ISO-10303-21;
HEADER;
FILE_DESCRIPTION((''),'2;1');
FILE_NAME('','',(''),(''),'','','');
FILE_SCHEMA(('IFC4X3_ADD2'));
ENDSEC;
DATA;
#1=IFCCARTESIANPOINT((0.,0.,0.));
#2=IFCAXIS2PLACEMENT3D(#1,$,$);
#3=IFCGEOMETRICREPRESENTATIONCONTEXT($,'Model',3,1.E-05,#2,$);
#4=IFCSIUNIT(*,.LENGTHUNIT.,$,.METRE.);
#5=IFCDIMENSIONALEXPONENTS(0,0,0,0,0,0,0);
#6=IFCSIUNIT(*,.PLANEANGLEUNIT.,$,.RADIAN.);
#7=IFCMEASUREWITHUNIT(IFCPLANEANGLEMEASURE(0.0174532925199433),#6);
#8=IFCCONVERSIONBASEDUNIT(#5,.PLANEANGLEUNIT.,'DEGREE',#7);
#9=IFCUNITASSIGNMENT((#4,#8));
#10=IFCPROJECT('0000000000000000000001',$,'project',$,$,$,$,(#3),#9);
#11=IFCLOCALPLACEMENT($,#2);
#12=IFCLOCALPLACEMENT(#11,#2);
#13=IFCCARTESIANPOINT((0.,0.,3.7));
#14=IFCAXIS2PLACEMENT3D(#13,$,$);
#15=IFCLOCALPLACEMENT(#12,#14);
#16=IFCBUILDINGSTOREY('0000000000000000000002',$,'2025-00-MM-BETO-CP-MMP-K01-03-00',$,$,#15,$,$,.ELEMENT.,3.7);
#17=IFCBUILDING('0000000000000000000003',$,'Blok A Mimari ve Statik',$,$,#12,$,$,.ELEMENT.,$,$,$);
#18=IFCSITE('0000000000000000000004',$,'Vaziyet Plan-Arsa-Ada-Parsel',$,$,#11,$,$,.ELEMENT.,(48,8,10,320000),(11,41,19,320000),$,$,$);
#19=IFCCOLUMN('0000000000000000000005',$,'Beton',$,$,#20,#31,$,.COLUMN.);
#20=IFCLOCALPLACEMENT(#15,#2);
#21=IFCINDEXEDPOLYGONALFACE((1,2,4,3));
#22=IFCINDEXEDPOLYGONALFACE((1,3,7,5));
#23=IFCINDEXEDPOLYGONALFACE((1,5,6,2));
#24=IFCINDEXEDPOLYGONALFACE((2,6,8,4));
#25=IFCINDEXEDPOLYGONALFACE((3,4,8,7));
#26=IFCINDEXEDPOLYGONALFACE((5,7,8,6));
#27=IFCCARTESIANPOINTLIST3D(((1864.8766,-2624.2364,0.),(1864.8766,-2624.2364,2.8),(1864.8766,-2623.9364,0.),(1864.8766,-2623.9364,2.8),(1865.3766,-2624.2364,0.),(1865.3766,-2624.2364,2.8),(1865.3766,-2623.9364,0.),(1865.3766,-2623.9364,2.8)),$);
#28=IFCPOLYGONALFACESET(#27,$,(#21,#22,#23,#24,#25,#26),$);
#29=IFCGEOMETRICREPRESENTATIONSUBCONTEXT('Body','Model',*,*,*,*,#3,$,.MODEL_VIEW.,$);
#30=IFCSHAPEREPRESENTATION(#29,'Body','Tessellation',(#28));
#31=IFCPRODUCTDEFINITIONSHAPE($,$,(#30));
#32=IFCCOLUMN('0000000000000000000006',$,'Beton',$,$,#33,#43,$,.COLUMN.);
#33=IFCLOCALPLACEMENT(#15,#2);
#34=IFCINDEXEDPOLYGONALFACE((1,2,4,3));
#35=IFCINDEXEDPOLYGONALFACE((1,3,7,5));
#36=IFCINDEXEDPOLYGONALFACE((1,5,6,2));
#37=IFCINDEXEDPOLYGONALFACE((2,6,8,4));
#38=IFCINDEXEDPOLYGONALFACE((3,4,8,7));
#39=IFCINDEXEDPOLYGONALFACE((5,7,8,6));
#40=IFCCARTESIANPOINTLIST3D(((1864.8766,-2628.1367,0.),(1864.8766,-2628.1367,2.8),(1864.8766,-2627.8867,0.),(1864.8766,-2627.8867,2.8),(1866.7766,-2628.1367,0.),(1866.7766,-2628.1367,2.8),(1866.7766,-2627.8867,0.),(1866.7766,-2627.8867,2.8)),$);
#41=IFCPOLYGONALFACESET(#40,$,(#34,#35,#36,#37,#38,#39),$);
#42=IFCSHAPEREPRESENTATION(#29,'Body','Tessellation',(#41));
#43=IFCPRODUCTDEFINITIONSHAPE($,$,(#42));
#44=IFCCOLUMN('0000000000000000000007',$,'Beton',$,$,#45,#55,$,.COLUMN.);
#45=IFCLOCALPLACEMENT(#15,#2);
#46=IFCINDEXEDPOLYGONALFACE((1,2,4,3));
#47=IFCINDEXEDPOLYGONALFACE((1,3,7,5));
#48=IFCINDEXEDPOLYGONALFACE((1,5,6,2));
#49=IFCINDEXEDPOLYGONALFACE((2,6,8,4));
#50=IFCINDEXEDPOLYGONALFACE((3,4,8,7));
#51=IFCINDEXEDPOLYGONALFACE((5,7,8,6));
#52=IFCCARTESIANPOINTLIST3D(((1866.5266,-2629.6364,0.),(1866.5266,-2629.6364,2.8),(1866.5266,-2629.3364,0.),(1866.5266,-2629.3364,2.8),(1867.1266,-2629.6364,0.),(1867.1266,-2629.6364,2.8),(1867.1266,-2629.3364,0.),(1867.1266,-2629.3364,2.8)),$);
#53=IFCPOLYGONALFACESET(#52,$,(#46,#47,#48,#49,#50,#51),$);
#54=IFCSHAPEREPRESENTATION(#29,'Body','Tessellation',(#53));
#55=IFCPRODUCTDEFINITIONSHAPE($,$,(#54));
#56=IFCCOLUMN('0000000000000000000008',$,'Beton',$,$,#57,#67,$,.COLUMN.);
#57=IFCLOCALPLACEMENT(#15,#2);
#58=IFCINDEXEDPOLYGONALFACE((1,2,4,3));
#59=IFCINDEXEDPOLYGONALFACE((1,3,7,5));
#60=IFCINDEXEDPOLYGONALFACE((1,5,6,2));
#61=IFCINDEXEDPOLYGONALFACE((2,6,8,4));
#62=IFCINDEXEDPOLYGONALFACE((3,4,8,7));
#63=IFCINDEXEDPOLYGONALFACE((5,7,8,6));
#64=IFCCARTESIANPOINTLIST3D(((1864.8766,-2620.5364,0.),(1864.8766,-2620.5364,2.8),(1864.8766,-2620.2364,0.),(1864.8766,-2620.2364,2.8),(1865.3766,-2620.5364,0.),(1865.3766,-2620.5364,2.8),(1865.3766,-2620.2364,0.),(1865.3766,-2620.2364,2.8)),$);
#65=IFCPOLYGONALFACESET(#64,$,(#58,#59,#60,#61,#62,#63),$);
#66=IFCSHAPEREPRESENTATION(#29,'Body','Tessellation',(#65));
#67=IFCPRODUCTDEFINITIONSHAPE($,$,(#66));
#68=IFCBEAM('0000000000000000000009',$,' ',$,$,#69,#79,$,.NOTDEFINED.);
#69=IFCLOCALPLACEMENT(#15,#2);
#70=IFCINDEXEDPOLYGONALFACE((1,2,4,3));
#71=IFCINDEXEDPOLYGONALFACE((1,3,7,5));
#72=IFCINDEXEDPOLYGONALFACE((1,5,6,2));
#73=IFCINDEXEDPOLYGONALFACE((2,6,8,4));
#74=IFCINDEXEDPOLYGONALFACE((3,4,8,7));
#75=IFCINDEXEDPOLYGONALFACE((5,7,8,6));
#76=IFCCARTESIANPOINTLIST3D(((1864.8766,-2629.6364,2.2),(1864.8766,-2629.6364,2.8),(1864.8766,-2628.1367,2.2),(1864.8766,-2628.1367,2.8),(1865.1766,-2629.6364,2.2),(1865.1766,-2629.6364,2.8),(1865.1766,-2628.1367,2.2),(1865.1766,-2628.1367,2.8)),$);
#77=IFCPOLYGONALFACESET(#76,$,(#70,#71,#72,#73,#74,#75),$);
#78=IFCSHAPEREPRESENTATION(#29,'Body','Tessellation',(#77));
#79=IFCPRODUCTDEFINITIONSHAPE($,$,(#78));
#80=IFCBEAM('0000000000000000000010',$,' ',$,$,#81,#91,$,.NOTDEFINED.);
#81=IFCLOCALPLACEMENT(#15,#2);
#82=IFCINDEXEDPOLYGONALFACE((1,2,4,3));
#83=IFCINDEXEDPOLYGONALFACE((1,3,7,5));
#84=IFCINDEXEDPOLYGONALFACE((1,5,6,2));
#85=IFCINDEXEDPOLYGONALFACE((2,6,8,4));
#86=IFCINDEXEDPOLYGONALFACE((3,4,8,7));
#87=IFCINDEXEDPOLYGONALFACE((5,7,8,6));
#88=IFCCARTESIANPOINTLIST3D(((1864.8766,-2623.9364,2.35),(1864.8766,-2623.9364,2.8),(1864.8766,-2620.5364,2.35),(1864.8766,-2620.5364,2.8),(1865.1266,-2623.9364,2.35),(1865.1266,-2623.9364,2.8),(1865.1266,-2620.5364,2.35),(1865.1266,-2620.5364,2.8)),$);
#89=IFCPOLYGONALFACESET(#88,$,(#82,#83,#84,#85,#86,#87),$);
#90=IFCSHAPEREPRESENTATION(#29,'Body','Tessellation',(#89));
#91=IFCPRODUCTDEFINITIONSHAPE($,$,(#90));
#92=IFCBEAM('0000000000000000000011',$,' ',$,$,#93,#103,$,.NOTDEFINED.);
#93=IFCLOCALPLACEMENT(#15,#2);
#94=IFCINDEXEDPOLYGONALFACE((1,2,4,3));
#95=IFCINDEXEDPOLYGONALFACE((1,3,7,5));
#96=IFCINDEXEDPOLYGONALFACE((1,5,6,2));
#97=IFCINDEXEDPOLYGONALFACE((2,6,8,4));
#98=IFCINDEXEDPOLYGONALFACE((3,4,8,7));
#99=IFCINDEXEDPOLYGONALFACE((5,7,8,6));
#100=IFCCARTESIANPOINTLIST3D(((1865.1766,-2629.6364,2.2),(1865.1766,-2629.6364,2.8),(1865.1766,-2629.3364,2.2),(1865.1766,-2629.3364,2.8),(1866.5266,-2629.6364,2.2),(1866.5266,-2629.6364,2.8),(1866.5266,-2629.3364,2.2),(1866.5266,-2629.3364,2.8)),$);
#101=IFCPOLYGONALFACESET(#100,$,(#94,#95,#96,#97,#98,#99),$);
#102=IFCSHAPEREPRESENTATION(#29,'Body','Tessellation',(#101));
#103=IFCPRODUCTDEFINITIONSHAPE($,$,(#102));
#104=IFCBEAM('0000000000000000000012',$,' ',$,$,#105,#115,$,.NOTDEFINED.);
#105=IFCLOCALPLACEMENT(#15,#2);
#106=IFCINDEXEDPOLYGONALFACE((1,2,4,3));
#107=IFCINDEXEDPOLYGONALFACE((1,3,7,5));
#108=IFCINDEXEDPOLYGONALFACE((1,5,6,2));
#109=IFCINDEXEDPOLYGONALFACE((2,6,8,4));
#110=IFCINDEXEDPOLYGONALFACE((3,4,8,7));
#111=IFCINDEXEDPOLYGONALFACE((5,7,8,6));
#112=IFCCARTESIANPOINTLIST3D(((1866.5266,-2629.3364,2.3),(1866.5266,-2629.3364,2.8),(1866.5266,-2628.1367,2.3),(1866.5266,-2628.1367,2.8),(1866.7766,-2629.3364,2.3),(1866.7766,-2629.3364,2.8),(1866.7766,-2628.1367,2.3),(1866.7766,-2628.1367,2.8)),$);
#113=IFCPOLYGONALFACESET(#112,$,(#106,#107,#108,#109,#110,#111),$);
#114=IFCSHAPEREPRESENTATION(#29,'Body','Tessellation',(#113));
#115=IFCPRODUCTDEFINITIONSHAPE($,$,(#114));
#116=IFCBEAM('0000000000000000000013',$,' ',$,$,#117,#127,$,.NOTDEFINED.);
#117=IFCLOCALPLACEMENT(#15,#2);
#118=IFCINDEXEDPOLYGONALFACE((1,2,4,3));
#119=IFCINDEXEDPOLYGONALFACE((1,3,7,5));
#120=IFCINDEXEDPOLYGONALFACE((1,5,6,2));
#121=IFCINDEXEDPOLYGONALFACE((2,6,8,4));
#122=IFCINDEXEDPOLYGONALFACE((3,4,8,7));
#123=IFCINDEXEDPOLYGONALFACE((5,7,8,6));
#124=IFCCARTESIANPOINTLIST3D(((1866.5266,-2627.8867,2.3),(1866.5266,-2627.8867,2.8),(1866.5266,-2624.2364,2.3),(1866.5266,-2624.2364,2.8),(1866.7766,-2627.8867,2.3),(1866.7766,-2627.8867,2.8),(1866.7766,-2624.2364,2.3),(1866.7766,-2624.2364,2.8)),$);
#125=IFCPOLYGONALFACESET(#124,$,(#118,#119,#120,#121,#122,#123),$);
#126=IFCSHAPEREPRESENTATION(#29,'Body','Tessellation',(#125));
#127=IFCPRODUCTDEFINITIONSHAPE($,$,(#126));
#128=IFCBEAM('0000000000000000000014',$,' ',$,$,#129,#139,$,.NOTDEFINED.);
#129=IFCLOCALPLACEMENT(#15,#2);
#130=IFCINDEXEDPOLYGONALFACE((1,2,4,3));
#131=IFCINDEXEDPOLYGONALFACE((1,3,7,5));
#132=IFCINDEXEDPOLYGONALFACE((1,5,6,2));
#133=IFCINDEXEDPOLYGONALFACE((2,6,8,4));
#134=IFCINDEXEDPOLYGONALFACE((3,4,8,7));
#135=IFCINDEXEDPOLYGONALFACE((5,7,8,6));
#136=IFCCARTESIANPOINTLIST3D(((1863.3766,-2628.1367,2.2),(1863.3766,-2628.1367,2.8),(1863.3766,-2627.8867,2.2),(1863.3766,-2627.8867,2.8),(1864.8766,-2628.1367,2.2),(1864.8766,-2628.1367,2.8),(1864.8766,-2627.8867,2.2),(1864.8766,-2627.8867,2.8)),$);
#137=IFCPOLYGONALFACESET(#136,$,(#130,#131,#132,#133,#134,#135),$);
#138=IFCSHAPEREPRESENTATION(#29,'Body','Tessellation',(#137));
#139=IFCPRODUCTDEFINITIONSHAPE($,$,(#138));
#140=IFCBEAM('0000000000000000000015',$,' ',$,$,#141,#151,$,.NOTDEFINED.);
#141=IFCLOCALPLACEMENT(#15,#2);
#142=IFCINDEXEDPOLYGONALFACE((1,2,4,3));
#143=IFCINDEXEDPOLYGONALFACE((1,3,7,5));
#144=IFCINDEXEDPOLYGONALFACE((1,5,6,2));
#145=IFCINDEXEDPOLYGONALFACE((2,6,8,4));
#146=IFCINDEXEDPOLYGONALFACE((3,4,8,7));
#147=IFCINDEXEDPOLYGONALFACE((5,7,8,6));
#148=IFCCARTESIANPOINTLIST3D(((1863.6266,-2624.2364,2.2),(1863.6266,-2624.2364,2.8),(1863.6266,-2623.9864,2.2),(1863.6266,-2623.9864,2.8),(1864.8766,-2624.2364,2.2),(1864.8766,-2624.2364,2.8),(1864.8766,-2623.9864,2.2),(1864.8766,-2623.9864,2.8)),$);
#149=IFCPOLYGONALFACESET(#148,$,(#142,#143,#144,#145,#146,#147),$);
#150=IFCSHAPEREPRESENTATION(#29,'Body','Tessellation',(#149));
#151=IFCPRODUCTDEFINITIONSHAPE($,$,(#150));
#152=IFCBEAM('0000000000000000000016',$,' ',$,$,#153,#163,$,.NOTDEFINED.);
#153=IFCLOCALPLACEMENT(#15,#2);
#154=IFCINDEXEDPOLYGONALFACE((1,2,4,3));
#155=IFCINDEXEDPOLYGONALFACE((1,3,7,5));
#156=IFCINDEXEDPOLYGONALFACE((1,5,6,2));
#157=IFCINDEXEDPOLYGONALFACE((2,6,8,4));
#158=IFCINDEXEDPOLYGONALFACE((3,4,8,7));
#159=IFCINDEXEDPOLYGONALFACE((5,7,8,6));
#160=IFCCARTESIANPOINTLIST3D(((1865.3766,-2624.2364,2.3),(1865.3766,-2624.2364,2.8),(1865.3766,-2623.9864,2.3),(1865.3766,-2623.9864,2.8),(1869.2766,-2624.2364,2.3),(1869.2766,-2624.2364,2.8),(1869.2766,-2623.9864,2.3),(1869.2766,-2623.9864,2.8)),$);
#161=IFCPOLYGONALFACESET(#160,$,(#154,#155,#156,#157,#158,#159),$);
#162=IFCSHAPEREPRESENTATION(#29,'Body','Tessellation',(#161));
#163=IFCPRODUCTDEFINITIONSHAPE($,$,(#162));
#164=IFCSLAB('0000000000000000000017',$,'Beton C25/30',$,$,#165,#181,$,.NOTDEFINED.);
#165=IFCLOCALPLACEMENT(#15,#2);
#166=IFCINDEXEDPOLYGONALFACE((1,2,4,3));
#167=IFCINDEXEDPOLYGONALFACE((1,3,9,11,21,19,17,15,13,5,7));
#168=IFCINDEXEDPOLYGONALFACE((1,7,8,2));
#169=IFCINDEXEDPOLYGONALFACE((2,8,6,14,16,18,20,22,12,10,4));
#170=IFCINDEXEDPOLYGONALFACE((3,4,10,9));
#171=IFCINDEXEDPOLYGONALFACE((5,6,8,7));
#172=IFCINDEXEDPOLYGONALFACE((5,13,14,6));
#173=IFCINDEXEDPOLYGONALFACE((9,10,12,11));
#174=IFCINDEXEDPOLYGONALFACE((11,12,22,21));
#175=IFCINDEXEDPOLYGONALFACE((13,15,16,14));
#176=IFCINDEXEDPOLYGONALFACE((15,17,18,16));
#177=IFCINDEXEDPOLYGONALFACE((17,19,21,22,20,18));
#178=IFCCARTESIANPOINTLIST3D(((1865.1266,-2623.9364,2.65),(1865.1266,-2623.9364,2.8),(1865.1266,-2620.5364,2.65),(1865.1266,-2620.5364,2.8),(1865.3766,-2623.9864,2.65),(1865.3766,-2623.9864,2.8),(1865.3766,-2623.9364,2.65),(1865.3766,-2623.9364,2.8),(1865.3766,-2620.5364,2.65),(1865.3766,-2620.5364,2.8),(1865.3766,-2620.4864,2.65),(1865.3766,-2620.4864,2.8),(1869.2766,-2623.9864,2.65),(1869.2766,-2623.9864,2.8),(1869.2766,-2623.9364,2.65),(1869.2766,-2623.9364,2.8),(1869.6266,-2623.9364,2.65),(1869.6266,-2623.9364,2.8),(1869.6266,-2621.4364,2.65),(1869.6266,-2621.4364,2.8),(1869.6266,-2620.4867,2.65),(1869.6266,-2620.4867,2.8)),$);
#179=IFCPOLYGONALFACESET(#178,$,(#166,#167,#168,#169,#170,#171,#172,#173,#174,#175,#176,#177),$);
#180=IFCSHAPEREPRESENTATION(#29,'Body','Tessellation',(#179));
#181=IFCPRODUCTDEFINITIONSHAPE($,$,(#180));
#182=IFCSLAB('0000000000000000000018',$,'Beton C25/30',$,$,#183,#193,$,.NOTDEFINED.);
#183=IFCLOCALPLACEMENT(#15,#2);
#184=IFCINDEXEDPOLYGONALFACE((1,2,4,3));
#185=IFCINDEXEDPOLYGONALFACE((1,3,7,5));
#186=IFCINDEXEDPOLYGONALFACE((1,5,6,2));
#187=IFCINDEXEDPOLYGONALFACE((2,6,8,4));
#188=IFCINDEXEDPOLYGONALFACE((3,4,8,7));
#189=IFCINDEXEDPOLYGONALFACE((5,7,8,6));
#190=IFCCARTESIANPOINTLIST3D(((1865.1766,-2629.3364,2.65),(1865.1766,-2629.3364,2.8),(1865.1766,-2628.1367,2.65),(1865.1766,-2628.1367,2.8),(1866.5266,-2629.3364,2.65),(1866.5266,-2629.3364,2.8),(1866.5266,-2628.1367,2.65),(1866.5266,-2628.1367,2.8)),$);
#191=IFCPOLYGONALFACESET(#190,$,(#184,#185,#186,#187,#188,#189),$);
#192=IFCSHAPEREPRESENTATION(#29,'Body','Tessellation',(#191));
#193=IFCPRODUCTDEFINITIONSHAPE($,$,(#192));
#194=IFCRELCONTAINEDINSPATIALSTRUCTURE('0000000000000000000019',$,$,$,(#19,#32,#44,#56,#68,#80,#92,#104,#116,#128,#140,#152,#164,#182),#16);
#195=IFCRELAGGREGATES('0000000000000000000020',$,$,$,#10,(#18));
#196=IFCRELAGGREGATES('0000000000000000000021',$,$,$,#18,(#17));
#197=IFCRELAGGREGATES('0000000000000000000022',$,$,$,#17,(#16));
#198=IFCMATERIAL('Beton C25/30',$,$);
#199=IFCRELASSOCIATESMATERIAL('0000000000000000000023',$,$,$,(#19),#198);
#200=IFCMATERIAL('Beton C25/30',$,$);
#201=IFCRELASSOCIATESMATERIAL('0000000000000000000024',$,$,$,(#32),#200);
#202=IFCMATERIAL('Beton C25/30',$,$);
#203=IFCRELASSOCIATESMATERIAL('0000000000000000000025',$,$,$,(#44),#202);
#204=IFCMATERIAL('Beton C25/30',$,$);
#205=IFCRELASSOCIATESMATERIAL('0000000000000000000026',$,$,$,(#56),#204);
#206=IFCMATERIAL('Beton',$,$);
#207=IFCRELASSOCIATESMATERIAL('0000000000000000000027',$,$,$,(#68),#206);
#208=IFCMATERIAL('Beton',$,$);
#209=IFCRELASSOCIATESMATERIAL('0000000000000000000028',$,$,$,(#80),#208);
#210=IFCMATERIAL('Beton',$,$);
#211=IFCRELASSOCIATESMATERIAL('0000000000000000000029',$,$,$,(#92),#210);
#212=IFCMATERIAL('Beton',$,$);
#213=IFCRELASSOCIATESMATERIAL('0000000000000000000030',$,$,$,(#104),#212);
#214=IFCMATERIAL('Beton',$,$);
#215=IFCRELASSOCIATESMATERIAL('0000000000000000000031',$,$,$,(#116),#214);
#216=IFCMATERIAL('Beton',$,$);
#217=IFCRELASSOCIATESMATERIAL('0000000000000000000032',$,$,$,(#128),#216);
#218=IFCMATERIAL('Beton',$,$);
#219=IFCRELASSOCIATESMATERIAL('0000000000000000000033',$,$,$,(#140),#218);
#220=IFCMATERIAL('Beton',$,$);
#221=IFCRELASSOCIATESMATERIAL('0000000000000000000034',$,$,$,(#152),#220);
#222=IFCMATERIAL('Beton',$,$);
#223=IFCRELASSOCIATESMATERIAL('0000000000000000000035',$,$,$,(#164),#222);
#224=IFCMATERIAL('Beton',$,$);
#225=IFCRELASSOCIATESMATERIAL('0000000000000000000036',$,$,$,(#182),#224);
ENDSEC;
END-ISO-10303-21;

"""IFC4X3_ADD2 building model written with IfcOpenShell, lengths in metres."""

from ifc_helpers import new_model, entity, si_unit, converted_unit, frame, frame_2d, origin, origin_with_axes, place, context, subcontext, project, spatial, polyline, rectangle, outline, extrude, material, element, save


model = new_model("IFC4X3_ADD2")

# Units and contexts
model_context = context("Model", 3, precision=1e-05, world=origin())
body_context = subcontext(model_context, "Body", "Model", "MODEL_VIEW")
ifc_project = project(units=[si_unit("LENGTHUNIT", "METRE"), converted_unit("PLANEANGLEUNIT", "DEGREE", entity("IfcPlaneAngleMeasure", 0.0174532925199433), si_unit("PLANEANGLEUNIT", "RADIAN"), dimensions=[0, 0, 0, 0, 0, 0, 0])], contexts=[model_context])

# Site, building, storey
site_placement = place(None, origin())
site = spatial("IfcSite", under=ifc_project, at=site_placement, Name="Vaziyet Plan-Arsa-Ada-Parsel", CompositionType="ELEMENT", RefLatitude=(48, 8, 10, 320000), RefLongitude=(11, 41, 19, 320000))
building_placement = place(site_placement, origin())
building = spatial("IfcBuilding", under=site, at=building_placement, Name="Blok A Mimari ve Statik", CompositionType="ELEMENT")
storey_placement = place(building_placement, frame((0.0, 0.0, 3.7)))
storey = spatial("IfcBuildingStorey", under=building, at=storey_placement, Name="2025-00-MM-BETO-CP-MMP-K01-03-00", CompositionType="ELEMENT", Elevation=3.7)

# Columns
ifc_material_1 = material(Name="Beton C25/30")
column_1_placement = place(storey_placement, frame((1864.8766, -2624.2364, 0.0)))
element("IfcColumn", 1, at=column_1_placement, inside=storey, material=ifc_material_1, Name="Beton", PredefinedType="COLUMN", context=body_context, shape_type="SweptSolid", body=[
    extrude(outline(polyline([(0.0, 0.0), (0.5, 0.0), (0.5, 0.3), (0.0, 0.3), (0.0, 0.0)])), origin_with_axes(), (0.0, 0.0, 1.0), 2.8),
])
ifc_material_2 = material(Name="Beton C25/30")
column_2_placement = place(storey_placement, frame((1864.8766, -2628.1367, 0.0)))
element("IfcColumn", 2, at=column_2_placement, inside=storey, material=ifc_material_2, Name="Beton", PredefinedType="COLUMN", context=body_context, shape_type="SweptSolid", body=[
    extrude(outline(polyline([(1.9, 0.25), (0.0, 0.25), (0.0, 0.0), (1.9, 0.0), (1.9, 0.25)])), origin_with_axes(), (0.0, 0.0, 1.0), 2.8),
])
ifc_material_3 = material(Name="Beton C25/30")
column_3_placement = place(storey_placement, frame((1866.5266, -2629.6364, 0.0)))
element("IfcColumn", 3, at=column_3_placement, inside=storey, material=ifc_material_3, Name="Beton", PredefinedType="COLUMN", context=body_context, shape_type="SweptSolid", body=[
    extrude(outline(polyline([(0.0, 0.3), (0.0, 0.0), (0.6, 0.0), (0.6, 0.3), (0.0, 0.3)])), origin_with_axes(), (0.0, 0.0, 1.0), 2.8),
])
ifc_material_4 = material(Name="Beton C25/30")
column_4_placement = place(storey_placement, frame((1864.8766, -2620.5364, 0.0)))
element("IfcColumn", 4, at=column_4_placement, inside=storey, material=ifc_material_4, Name="Beton", PredefinedType="COLUMN", context=body_context, shape_type="SweptSolid", body=[
    extrude(outline(polyline([(0.0, 0.0), (0.5, 0.0), (0.5, 0.3), (0.0, 0.3), (0.0, 0.0)])), origin_with_axes(), (0.0, 0.0, 1.0), 2.8),
])

# Beams
ifc_material_5 = material(Name="Beton")
beam_1_placement = place(storey_placement, frame((1864.8766, -2628.1367, 2.2), z_axis=(0.0, 0.0, 1.0), x_axis=(0.0, -1.0, 0.0)))
element("IfcBeam", 5, at=beam_1_placement, inside=storey, material=ifc_material_5, Name=" ", PredefinedType="NOTDEFINED", context=body_context, shape_type="SweptSolid", body=[
    extrude(rectangle(XDim=0.3, YDim=0.6, at=frame_2d((0.15, 0.3), x_axis=(1.0, 0.0))), frame((0.0, 0.0, 0.0), z_axis=(1.0, 0.0, 0.0), x_axis=(0.0, 1.0, 0.0)), (0.0, 0.0, 1.0), 1.4997),
])
ifc_material_6 = material(Name="Beton")
beam_2_placement = place(storey_placement, frame((1864.8766, -2620.5364, 2.35), z_axis=(0.0, 0.0, 1.0), x_axis=(0.0, -1.0, 0.0)))
element("IfcBeam", 6, at=beam_2_placement, inside=storey, material=ifc_material_6, Name=" ", PredefinedType="NOTDEFINED", context=body_context, shape_type="SweptSolid", body=[
    extrude(rectangle(XDim=0.25, YDim=0.45, at=frame_2d((0.125, 0.225), x_axis=(1.0, 0.0))), frame((0.0, 0.0, 0.0), z_axis=(1.0, 0.0, 0.0), x_axis=(0.0, 1.0, 0.0)), (0.0, 0.0, 1.0), 3.4),
])
ifc_material_7 = material(Name="Beton")
beam_3_placement = place(storey_placement, frame((1865.1766, -2629.6364, 2.2), z_axis=(0.0, 0.0, 1.0), x_axis=(1.0, 0.0, 0.0)))
element("IfcBeam", 7, at=beam_3_placement, inside=storey, material=ifc_material_7, Name=" ", PredefinedType="NOTDEFINED", context=body_context, shape_type="SweptSolid", body=[
    extrude(rectangle(XDim=0.3, YDim=0.6, at=frame_2d((0.15, 0.3), x_axis=(1.0, 0.0))), frame((0.0, 0.0, 0.0), z_axis=(1.0, 0.0, 0.0), x_axis=(0.0, 1.0, 0.0)), (0.0, 0.0, 1.0), 1.35),
])
ifc_material_8 = material(Name="Beton")
beam_4_placement = place(storey_placement, frame((1866.5266, -2628.1367, 2.3), z_axis=(0.0, 0.0, 1.0), x_axis=(0.0, -1.0, 0.0)))
element("IfcBeam", 8, at=beam_4_placement, inside=storey, material=ifc_material_8, Name=" ", PredefinedType="NOTDEFINED", context=body_context, shape_type="SweptSolid", body=[
    extrude(rectangle(XDim=0.25, YDim=0.5, at=frame_2d((0.125, 0.25), x_axis=(1.0, 0.0))), frame((0.0, 0.0, 0.0), z_axis=(1.0, 0.0, 0.0), x_axis=(0.0, 1.0, 0.0)), (0.0, 0.0, 1.0), 1.1997),
])
ifc_material_9 = material(Name="Beton")
beam_5_placement = place(storey_placement, frame((1866.7766, -2627.8867, 2.3), z_axis=(0.0, 0.0, 1.0), x_axis=(0.0, 1.0, 0.0)))
element("IfcBeam", 9, at=beam_5_placement, inside=storey, material=ifc_material_9, Name=" ", PredefinedType="NOTDEFINED", context=body_context, shape_type="SweptSolid", body=[
    extrude(rectangle(XDim=0.25, YDim=0.5, at=frame_2d((0.125, 0.25), x_axis=(1.0, 0.0))), frame((0.0, 0.0, 0.0), z_axis=(1.0, 0.0, 0.0), x_axis=(0.0, 1.0, 0.0)), (0.0, 0.0, 1.0), 3.6503),
])
ifc_material_10 = material(Name="Beton")
beam_6_placement = place(storey_placement, frame((1863.3766, -2628.1367, 2.2), z_axis=(0.0, 0.0, 1.0), x_axis=(1.0, 0.000001, 0.0)))
element("IfcBeam", 10, at=beam_6_placement, inside=storey, material=ifc_material_10, Name=" ", PredefinedType="NOTDEFINED", context=body_context, shape_type="SweptSolid", body=[
    extrude(rectangle(XDim=0.25, YDim=0.6, at=frame_2d((0.125, 0.3), x_axis=(1.0, 0.0))), frame((0.0, 0.0, 0.0), z_axis=(1.0, 0.0, 0.0), x_axis=(0.0, 1.0, 0.0)), (0.0, 0.0, 1.0), 1.5),
])
ifc_material_11 = material(Name="Beton")
beam_7_placement = place(storey_placement, frame((1863.6266, -2624.2364, 2.2), z_axis=(0.0, 0.0, 1.0), x_axis=(1.0, 0.000002, 0.0)))
element("IfcBeam", 11, at=beam_7_placement, inside=storey, material=ifc_material_11, Name=" ", PredefinedType="NOTDEFINED", context=body_context, shape_type="SweptSolid", body=[
    extrude(rectangle(XDim=0.25, YDim=0.6, at=frame_2d((0.125, 0.3), x_axis=(1.0, 0.0))), frame((0.0, 0.0, 0.0), z_axis=(1.0, 0.0, 0.0), x_axis=(0.0, 1.0, 0.0)), (0.0, 0.0, 1.0), 1.25),
])
ifc_material_12 = material(Name="Beton")
beam_8_placement = place(storey_placement, frame((1865.3766, -2624.2364, 2.3), z_axis=(0.0, 0.0, 1.0), x_axis=(1.0, 0.0, 0.0)))
element("IfcBeam", 12, at=beam_8_placement, inside=storey, material=ifc_material_12, Name=" ", PredefinedType="NOTDEFINED", context=body_context, shape_type="SweptSolid", body=[
    extrude(rectangle(XDim=0.25, YDim=0.5, at=frame_2d((0.125, 0.25), x_axis=(1.0, 0.0))), frame((0.0, 0.0, 0.0), z_axis=(1.0, 0.0, 0.0), x_axis=(0.0, 1.0, 0.0)), (0.0, 0.0, 1.0), 3.9),
])

# Slabs
ifc_material_13 = material(Name="Beton")
slab_1_placement = place(storey_placement, frame((1865.1266, -2623.9864, 2.65)))
element("IfcSlab", 13, at=slab_1_placement, inside=storey, material=ifc_material_13, Name="Beton C25/30", PredefinedType="NOTDEFINED", context=body_context, shape_type="SweptSolid", body=[
    extrude(outline(polyline([(0.25, 3.5), (0.25, 3.45), (0.0, 3.45), (0.0, 0.05), (0.25, 0.05), (0.25, 0.0), (4.15, 0.0), (4.15, 0.05), (4.5, 0.05), (4.5, 2.55), (4.5, 3.4997), (0.25, 3.5)])), origin_with_axes(), (0.0, 0.0, 1.0), 0.15),
])
ifc_material_14 = material(Name="Beton")
slab_2_placement = place(storey_placement, frame((1865.1766, -2629.3364, 2.65)))
element("IfcSlab", 14, at=slab_2_placement, inside=storey, material=ifc_material_14, Name="Beton C25/30", PredefinedType="NOTDEFINED", context=body_context, shape_type="SweptSolid", body=[
    extrude(rectangle(XDim=1.35, YDim=1.1997, at=frame_2d((0.675, 0.5998), x_axis=(1.0, 0.0))), origin_with_axes(), (0.0, 0.0, 1.0), 0.15),
])

save(model, "model.ifc")
